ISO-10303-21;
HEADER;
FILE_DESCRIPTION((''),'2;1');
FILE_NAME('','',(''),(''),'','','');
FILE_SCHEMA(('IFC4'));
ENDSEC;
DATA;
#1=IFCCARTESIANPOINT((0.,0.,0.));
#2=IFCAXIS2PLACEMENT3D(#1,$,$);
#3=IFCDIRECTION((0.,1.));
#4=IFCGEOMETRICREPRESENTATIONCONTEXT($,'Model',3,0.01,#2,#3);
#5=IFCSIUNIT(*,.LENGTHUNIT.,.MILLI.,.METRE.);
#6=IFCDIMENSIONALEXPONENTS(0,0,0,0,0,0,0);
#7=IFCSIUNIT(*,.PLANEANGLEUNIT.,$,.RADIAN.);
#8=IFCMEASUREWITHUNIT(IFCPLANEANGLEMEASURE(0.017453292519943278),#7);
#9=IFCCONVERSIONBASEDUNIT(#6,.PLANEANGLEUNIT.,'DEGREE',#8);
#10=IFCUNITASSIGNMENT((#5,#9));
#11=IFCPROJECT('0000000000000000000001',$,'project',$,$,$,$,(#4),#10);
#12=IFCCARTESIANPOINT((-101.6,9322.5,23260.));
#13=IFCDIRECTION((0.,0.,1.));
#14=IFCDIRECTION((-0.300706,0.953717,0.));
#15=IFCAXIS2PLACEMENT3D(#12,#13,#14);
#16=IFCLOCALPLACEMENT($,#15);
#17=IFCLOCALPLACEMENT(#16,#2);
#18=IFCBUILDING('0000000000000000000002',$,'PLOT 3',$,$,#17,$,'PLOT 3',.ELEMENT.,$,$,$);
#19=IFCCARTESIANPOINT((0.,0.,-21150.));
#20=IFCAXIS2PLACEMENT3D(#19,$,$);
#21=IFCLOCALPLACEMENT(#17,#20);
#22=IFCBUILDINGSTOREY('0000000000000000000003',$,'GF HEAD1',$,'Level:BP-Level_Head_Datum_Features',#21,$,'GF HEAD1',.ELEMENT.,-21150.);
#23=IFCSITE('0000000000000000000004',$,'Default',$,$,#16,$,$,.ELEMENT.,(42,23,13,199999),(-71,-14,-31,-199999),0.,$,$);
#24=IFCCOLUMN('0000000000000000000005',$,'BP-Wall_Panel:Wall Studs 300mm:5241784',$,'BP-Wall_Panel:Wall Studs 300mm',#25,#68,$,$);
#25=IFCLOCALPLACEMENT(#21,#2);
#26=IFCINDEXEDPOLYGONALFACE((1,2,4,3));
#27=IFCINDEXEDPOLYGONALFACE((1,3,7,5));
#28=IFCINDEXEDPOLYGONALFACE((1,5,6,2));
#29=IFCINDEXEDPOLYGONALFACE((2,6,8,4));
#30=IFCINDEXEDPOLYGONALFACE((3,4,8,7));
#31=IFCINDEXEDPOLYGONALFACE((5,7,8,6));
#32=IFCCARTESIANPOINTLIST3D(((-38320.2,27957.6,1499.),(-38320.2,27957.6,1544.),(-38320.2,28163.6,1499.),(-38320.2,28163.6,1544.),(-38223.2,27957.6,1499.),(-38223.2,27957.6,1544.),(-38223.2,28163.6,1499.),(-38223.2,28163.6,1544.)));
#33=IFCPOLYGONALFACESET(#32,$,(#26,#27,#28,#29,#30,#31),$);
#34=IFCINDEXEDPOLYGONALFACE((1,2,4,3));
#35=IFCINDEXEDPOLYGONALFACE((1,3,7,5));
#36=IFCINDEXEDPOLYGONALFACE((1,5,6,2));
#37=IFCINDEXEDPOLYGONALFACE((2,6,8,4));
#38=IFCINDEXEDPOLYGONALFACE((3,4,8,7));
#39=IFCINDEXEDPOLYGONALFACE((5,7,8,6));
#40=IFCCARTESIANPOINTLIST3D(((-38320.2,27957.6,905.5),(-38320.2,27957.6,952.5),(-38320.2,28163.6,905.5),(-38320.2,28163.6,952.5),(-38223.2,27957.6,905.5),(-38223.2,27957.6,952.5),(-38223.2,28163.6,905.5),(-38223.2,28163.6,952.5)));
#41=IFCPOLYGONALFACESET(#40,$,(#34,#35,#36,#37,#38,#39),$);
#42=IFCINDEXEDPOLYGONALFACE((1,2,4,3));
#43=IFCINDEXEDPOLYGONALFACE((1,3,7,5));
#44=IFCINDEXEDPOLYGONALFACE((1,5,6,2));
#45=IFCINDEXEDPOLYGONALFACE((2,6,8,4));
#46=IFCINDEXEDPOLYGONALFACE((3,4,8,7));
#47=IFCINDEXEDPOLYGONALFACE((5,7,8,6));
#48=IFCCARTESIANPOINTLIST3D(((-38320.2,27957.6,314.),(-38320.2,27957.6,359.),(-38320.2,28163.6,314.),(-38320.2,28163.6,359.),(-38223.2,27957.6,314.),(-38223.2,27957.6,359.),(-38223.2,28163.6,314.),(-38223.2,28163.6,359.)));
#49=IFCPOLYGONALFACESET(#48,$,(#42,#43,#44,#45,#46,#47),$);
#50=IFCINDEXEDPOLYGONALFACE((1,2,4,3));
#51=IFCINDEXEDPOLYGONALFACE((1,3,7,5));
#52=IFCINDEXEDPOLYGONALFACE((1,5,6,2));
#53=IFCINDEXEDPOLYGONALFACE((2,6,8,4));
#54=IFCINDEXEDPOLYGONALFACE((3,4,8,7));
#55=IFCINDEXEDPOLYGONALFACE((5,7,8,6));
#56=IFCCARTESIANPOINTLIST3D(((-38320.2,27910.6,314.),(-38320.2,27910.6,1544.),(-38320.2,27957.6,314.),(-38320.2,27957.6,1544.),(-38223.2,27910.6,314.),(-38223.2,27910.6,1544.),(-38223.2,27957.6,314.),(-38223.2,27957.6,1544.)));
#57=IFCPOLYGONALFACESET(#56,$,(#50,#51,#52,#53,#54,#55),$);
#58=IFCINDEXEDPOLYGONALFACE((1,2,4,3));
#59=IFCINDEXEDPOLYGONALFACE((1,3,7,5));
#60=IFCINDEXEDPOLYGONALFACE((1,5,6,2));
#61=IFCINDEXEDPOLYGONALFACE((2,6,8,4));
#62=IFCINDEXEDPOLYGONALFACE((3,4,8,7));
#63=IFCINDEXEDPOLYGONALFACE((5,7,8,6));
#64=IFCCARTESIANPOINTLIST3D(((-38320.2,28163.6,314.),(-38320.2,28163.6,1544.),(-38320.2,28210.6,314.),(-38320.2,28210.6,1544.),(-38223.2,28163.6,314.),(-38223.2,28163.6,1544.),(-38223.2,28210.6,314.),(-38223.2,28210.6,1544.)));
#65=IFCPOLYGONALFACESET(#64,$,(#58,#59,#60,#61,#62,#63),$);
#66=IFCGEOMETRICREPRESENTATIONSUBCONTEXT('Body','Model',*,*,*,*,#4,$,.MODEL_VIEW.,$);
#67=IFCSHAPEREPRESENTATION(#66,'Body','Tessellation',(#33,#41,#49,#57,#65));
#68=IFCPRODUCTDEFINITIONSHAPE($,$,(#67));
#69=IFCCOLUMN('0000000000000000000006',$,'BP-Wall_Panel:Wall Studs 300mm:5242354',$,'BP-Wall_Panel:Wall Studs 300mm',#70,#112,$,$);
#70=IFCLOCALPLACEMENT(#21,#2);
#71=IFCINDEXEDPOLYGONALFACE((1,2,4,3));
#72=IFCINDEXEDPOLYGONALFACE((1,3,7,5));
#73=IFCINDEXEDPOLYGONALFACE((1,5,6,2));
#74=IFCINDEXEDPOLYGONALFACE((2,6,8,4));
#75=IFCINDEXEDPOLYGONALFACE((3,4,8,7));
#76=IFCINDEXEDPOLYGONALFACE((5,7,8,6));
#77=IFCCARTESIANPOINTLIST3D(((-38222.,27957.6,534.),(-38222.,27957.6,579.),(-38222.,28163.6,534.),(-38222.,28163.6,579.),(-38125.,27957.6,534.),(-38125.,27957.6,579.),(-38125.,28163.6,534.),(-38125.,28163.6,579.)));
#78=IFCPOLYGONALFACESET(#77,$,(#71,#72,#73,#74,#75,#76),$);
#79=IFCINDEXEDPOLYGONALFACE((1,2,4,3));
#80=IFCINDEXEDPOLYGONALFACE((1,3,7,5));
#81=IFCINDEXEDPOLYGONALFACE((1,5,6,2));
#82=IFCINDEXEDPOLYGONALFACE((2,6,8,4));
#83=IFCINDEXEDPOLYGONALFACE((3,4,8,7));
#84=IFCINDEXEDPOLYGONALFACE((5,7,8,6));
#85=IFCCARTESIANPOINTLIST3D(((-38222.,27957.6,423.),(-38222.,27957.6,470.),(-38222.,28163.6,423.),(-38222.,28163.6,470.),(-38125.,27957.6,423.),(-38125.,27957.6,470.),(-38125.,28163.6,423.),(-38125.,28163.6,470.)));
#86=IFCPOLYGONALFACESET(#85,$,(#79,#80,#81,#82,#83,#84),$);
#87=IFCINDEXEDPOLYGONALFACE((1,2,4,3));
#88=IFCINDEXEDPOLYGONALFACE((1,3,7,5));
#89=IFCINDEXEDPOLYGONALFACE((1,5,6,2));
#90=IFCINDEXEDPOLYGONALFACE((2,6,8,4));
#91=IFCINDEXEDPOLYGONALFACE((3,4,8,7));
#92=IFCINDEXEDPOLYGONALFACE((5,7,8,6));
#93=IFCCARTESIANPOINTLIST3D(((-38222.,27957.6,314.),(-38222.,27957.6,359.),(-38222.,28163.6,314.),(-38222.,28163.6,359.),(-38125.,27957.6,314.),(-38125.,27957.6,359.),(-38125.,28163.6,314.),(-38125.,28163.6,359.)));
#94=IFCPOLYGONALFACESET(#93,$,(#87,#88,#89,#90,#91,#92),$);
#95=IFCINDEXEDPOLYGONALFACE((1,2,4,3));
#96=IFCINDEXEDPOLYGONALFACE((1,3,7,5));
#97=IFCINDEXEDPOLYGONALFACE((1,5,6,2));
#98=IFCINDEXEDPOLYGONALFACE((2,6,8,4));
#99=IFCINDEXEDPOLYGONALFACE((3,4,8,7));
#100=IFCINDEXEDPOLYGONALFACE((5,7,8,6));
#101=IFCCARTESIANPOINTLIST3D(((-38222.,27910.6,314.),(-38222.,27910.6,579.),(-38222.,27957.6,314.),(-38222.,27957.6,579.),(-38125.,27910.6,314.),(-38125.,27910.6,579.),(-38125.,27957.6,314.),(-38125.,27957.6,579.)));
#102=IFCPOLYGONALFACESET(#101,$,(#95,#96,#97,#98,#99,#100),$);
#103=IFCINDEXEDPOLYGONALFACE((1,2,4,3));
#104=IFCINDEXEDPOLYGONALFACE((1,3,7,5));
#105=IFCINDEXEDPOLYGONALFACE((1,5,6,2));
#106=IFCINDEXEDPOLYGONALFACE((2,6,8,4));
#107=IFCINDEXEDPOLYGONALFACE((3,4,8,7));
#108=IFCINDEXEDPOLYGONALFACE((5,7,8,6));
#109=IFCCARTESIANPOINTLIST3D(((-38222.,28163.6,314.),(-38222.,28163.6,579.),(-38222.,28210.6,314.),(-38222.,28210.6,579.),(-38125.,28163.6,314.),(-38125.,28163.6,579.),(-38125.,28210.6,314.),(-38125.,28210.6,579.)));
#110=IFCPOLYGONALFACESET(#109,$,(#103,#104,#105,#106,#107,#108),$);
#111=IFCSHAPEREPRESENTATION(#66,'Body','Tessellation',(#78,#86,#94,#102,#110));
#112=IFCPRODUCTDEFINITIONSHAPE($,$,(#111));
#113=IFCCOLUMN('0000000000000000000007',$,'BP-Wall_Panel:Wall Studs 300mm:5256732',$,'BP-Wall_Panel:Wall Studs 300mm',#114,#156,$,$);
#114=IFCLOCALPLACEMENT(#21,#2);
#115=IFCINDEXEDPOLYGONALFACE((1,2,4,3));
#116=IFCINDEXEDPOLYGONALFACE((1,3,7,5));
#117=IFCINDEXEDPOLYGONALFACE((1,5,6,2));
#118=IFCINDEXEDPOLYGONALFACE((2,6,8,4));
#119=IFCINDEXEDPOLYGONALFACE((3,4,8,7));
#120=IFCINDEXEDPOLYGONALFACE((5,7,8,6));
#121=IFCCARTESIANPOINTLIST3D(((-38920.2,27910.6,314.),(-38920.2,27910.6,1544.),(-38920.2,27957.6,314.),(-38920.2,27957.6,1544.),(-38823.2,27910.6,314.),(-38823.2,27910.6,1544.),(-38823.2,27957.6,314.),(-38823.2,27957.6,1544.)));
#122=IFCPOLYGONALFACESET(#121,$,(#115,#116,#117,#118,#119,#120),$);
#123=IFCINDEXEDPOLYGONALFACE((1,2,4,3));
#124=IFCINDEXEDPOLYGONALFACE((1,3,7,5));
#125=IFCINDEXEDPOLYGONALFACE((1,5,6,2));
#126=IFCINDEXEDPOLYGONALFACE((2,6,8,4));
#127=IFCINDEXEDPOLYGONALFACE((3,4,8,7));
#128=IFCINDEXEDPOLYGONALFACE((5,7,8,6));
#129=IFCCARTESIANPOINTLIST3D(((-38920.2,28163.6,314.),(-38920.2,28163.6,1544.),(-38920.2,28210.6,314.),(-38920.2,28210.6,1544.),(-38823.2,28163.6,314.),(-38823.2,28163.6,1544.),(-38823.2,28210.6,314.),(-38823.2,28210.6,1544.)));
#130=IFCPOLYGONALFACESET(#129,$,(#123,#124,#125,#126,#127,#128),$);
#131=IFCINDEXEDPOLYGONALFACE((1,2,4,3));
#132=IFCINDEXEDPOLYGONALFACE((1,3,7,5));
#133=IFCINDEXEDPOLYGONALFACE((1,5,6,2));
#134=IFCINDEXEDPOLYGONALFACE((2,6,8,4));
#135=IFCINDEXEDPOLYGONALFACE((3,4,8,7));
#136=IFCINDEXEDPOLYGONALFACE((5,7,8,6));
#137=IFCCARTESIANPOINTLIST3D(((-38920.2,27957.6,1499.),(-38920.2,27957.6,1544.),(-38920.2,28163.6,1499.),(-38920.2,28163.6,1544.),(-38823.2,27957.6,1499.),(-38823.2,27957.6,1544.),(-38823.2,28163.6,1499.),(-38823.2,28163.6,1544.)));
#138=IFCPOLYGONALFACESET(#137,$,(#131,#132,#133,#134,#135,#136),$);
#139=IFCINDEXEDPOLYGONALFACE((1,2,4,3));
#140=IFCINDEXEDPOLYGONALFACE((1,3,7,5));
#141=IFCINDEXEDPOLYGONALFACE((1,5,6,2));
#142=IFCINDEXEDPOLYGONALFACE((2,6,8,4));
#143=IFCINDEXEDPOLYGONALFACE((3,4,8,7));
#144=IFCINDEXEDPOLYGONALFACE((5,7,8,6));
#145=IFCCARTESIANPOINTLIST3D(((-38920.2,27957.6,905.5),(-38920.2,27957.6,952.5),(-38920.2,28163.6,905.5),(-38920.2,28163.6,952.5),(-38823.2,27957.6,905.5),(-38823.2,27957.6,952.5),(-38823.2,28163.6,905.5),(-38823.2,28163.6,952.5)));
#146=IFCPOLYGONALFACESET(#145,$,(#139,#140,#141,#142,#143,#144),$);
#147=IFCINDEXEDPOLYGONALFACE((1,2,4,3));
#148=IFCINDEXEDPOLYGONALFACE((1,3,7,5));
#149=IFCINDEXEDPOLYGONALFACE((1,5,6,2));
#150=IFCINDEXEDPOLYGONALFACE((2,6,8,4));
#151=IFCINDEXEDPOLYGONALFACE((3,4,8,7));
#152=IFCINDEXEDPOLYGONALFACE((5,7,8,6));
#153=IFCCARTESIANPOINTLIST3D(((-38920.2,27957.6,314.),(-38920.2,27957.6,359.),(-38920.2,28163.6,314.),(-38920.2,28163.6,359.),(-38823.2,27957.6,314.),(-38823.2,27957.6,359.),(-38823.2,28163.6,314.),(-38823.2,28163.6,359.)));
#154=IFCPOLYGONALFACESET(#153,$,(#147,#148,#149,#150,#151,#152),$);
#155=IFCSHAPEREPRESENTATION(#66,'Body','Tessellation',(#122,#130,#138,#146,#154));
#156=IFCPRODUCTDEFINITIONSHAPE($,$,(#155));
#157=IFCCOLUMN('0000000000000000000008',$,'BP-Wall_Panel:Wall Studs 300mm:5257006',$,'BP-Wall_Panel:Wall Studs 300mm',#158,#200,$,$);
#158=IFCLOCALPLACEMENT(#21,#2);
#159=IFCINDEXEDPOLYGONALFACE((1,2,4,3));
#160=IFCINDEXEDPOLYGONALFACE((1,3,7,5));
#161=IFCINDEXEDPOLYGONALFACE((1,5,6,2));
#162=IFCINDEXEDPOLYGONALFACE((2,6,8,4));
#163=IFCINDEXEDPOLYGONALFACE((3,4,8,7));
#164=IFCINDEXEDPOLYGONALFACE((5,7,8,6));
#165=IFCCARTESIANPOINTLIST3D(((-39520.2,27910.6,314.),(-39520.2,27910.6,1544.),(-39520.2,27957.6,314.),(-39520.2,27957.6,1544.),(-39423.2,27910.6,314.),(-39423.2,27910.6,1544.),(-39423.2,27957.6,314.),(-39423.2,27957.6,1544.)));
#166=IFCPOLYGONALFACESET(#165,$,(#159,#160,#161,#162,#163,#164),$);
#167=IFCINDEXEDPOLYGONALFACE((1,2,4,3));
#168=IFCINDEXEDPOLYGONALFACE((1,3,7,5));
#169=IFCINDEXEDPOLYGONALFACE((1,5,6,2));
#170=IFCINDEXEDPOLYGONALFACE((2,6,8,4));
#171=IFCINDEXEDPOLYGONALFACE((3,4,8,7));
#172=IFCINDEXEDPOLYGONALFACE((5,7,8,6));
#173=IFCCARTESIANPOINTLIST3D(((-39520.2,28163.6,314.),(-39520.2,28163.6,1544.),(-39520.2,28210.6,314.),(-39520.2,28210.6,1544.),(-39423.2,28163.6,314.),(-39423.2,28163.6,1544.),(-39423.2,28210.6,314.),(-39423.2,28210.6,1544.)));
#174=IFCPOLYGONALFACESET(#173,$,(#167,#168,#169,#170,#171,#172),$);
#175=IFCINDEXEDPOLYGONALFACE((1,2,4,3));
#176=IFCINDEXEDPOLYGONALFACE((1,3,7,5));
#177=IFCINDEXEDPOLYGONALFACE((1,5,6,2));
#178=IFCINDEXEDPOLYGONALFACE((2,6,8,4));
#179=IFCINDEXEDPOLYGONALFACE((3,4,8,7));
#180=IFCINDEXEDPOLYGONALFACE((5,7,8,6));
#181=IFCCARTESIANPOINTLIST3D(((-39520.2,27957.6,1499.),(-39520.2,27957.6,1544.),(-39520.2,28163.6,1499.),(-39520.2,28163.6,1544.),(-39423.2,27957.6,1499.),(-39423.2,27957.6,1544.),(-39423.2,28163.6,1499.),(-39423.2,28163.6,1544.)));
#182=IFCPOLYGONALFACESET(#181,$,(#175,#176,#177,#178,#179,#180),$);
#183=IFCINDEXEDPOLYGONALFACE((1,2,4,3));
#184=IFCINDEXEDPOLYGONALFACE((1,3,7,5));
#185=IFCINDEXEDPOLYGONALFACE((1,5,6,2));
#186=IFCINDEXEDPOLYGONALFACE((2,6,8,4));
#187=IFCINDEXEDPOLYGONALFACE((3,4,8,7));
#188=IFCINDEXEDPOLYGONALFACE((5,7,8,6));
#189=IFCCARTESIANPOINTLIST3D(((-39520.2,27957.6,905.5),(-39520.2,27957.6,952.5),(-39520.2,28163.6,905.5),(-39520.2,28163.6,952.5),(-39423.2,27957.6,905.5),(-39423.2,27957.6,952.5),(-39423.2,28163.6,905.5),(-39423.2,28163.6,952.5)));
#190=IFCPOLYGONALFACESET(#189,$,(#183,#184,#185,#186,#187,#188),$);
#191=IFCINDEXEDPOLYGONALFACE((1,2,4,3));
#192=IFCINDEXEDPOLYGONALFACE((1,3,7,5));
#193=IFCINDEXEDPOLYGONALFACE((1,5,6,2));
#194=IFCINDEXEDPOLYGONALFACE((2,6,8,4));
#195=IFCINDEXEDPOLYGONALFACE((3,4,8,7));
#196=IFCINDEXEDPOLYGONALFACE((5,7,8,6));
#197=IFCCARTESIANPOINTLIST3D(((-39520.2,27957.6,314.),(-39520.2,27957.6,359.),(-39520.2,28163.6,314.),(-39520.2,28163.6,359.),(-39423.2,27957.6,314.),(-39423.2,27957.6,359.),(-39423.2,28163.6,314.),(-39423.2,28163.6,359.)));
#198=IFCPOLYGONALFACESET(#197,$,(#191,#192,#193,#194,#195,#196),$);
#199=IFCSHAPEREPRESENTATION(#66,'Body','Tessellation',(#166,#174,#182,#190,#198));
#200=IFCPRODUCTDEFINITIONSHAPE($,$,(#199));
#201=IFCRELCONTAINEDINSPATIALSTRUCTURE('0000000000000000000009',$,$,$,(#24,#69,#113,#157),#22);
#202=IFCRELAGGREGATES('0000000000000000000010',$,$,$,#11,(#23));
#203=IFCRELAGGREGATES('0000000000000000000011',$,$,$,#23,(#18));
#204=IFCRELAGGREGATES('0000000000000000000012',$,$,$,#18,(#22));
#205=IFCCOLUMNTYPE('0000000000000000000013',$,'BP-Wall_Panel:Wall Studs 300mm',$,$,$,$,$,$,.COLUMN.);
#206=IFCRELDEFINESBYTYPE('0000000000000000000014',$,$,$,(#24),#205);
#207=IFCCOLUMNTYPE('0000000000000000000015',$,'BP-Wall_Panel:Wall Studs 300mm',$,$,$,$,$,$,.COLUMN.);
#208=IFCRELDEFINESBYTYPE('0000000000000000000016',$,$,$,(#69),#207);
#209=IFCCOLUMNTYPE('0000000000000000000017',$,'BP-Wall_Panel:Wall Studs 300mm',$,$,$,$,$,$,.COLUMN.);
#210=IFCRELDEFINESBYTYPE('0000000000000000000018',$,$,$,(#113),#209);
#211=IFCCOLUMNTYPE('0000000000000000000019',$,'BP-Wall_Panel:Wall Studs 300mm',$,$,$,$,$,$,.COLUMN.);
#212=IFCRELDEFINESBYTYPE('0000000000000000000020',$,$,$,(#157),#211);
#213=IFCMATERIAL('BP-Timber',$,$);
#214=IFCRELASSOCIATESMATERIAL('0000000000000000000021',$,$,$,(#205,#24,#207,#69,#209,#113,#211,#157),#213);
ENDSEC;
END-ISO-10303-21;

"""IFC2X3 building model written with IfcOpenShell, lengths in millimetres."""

from ifc_helpers import new_model, entity, si_unit, converted_unit, direction, frame, frame_2d, origin, place, context, subcontext, project, spatial, rectangle, extrude, source, transform, mapped, material, type_object, type_shapes, element, save


model = new_model("IFC2X3")

# Units and contexts
model_context = context("Model", 3, precision=0.01, world=origin(), true_north=direction((0.0, 1.0)))
body_context = subcontext(model_context, "Body", "Model", "MODEL_VIEW")
ifc_project = project(units=[si_unit("LENGTHUNIT", "METRE", prefix="MILLI"), converted_unit("PLANEANGLEUNIT", "DEGREE", entity("IfcPlaneAngleMeasure", 0.017453292519943278), si_unit("PLANEANGLEUNIT", "RADIAN"), dimensions=[0, 0, 0, 0, 0, 0, 0])], contexts=[model_context])

# Site, building, storey
site_placement = place(None, frame((-101.6, 9322.5, 23260.0), z_axis=(0.0, 0.0, 1.0), x_axis=(-0.300706, 0.953717, 0.0)))
site = spatial("IfcSite", under=ifc_project, at=site_placement, Name="Default", CompositionType="ELEMENT", RefLatitude=(42, 23, 13, 199999), RefLongitude=(-71, -14, -31, -199999), RefElevation=0.0)
building_placement = place(site_placement, origin())
building = spatial("IfcBuilding", under=site, at=building_placement, Name="PLOT 3", LongName="PLOT 3", CompositionType="ELEMENT")
storey_placement = place(building_placement, frame((0.0, 0.0, -21150.0)))
storey = spatial("IfcBuildingStorey", under=building, at=storey_placement, Name="GF HEAD1", ObjectType="Level:BP-Level_Head_Datum_Features", LongName="GF HEAD1", CompositionType="ELEMENT", Elevation=-21150.0)

# Columns
ifc_material_1 = material(Name="BP-Timber")
column_type_1 = type_object("IfcColumnType", Name="BP-Wall_Panel:Wall Studs 300mm", PredefinedType="COLUMN", material=ifc_material_1)
shared_shape_1 = source(origin(), body_context, "Body", "SweptSolid", [
    extrude(rectangle(XDim=97.0, YDim=206.0, at=frame_2d((0.0, 0.0), x_axis=(1.0, 0.0))), frame((-38271.7, 28060.6, -19651.0)), (0.0, 0.0, 1.0), 45.0),
    extrude(rectangle(XDim=97.0, YDim=206.0, at=frame_2d((0.0, 0.0), x_axis=(1.0, 0.0))), frame((-38271.7, 28060.6, -20244.5)), (0.0, 0.0, 1.0), 47.0),
    extrude(rectangle(XDim=97.0, YDim=206.0, at=frame_2d((0.0, 0.0), x_axis=(1.0, 0.0))), frame((-38271.7, 28060.6, -20836.0)), (0.0, 0.0, 1.0), 45.0),
    extrude(rectangle(XDim=47.0, YDim=97.0, at=frame_2d((0.0, 0.0), x_axis=(1.0, 0.0))), frame((-38271.7, 27934.1, -20836.0), z_axis=(0.0, 0.0, 1.0), x_axis=(0.0, 1.0, 0.0)), (0.0, 0.0, 1.0), 1230.0),
    extrude(rectangle(XDim=47.0, YDim=97.0, at=frame_2d((0.0, 0.0), x_axis=(1.0, 0.0))), frame((-38271.7, 28187.1, -20836.0), z_axis=(0.0, 0.0, 1.0), x_axis=(0.0, 1.0, 0.0)), (0.0, 0.0, 1.0), 1230.0),
])
type_shapes(column_type_1, [shared_shape_1])
column_1_placement = place(storey_placement, frame((0.0, 0.0, 21150.0)))
element("IfcColumn", 1, at=column_1_placement, inside=storey, type_object=column_type_1, material=ifc_material_1, Name="BP-Wall_Panel:Wall Studs 300mm:5241784", ObjectType="BP-Wall_Panel:Wall Studs 300mm", context=body_context, shape_type="MappedRepresentation", body=[
    mapped(shared_shape_1, transform((0.0, 0.0, 0.0), scale=1.0)),
])
column_type_2 = type_object("IfcColumnType", Name="BP-Wall_Panel:Wall Studs 300mm", PredefinedType="COLUMN", material=ifc_material_1)
shared_shape_2 = source(origin(), body_context, "Body", "SweptSolid", [
    extrude(rectangle(XDim=97.0, YDim=206.0, at=frame_2d((0.0, 0.0), x_axis=(1.0, 0.0))), frame((-38173.5, 28060.6, -20616.0)), (0.0, 0.0, 1.0), 45.0),
    extrude(rectangle(XDim=97.0, YDim=206.0, at=frame_2d((0.0, 0.0), x_axis=(1.0, 0.0))), frame((-38173.5, 28060.6, -20727.0)), (0.0, 0.0, 1.0), 47.0),
    extrude(rectangle(XDim=97.0, YDim=206.0, at=frame_2d((0.0, 0.0), x_axis=(1.0, 0.0))), frame((-38173.5, 28060.6, -20836.0)), (0.0, 0.0, 1.0), 45.0),
    extrude(rectangle(XDim=47.0, YDim=97.0, at=frame_2d((0.0, 0.0), x_axis=(1.0, 0.0))), frame((-38173.5, 27934.1, -20836.0), z_axis=(0.0, 0.0, 1.0), x_axis=(0.0, 1.0, 0.0)), (0.0, 0.0, 1.0), 265.0),
    extrude(rectangle(XDim=47.0, YDim=97.0, at=frame_2d((0.0, 0.0), x_axis=(1.0, 0.0))), frame((-38173.5, 28187.1, -20836.0), z_axis=(0.0, 0.0, 1.0), x_axis=(0.0, 1.0, 0.0)), (0.0, 0.0, 1.0), 265.0),
])
type_shapes(column_type_2, [shared_shape_2])
column_2_placement = place(storey_placement, frame((0.0, 0.0, 21150.0)))
element("IfcColumn", 2, at=column_2_placement, inside=storey, type_object=column_type_2, material=ifc_material_1, Name="BP-Wall_Panel:Wall Studs 300mm:5242354", ObjectType="BP-Wall_Panel:Wall Studs 300mm", context=body_context, shape_type="MappedRepresentation", body=[
    mapped(shared_shape_2, transform((0.0, 0.0, 0.0), scale=1.0)),
])
column_type_3 = type_object("IfcColumnType", Name="BP-Wall_Panel:Wall Studs 300mm", PredefinedType="COLUMN", material=ifc_material_1)
shared_shape_3 = source(origin(), body_context, "Body", "SweptSolid", [
    extrude(rectangle(XDim=47.0, YDim=97.0, at=frame_2d((0.0, 0.0), x_axis=(1.0, 0.0))), frame((-38871.7, 27934.1, -20836.0), z_axis=(0.0, 0.0, 1.0), x_axis=(0.0, 1.0, 0.0)), (0.0, 0.0, 1.0), 1230.0),
    extrude(rectangle(XDim=47.0, YDim=97.0, at=frame_2d((0.0, 0.0), x_axis=(1.0, 0.0))), frame((-38871.7, 28187.1, -20836.0), z_axis=(0.0, 0.0, 1.0), x_axis=(0.0, 1.0, 0.0)), (0.0, 0.0, 1.0), 1230.0),
    extrude(rectangle(XDim=97.0, YDim=206.0, at=frame_2d((0.0, 0.0), x_axis=(1.0, 0.0))), frame((-38871.7, 28060.6, -19651.0)), (0.0, 0.0, 1.0), 45.0),
    extrude(rectangle(XDim=97.0, YDim=206.0, at=frame_2d((0.0, 0.0), x_axis=(1.0, 0.0))), frame((-38871.7, 28060.6, -20244.5)), (0.0, 0.0, 1.0), 47.0),
    extrude(rectangle(XDim=97.0, YDim=206.0, at=frame_2d((0.0, 0.0), x_axis=(1.0, 0.0))), frame((-38871.7, 28060.6, -20836.0)), (0.0, 0.0, 1.0), 45.0),
])
type_shapes(column_type_3, [shared_shape_3])
column_3_placement = place(storey_placement, frame((0.0, 0.0, 21150.0)))
element("IfcColumn", 3, at=column_3_placement, inside=storey, type_object=column_type_3, material=ifc_material_1, Name="BP-Wall_Panel:Wall Studs 300mm:5256732", ObjectType="BP-Wall_Panel:Wall Studs 300mm", context=body_context, shape_type="MappedRepresentation", body=[
    mapped(shared_shape_3, transform((0.0, 0.0, 0.0), scale=1.0)),
])
column_type_4 = type_object("IfcColumnType", Name="BP-Wall_Panel:Wall Studs 300mm", PredefinedType="COLUMN", material=ifc_material_1)
shared_shape_4 = source(origin(), body_context, "Body", "SweptSolid", [
    extrude(rectangle(XDim=47.0, YDim=97.0, at=frame_2d((0.0, 0.0), x_axis=(1.0, 0.0))), frame((-39471.7, 27934.1, -20836.0), z_axis=(0.0, 0.0, 1.0), x_axis=(0.0, 1.0, 0.0)), (0.0, 0.0, 1.0), 1230.0),
    extrude(rectangle(XDim=47.0, YDim=97.0, at=frame_2d((0.0, 0.0), x_axis=(1.0, 0.0))), frame((-39471.7, 28187.1, -20836.0), z_axis=(0.0, 0.0, 1.0), x_axis=(0.0, 1.0, 0.0)), (0.0, 0.0, 1.0), 1230.0),
    extrude(rectangle(XDim=97.0, YDim=206.0, at=frame_2d((0.0, 0.0), x_axis=(1.0, 0.0))), frame((-39471.7, 28060.6, -19651.0)), (0.0, 0.0, 1.0), 45.0),
    extrude(rectangle(XDim=97.0, YDim=206.0, at=frame_2d((0.0, 0.0), x_axis=(1.0, 0.0))), frame((-39471.7, 28060.6, -20244.5)), (0.0, 0.0, 1.0), 47.0),
    extrude(rectangle(XDim=97.0, YDim=206.0, at=frame_2d((0.0, 0.0), x_axis=(1.0, 0.0))), frame((-39471.7, 28060.6, -20836.0)), (0.0, 0.0, 1.0), 45.0),
])
type_shapes(column_type_4, [shared_shape_4])
column_4_placement = place(storey_placement, frame((0.0, 0.0, 21150.0)))
element("IfcColumn", 4, at=column_4_placement, inside=storey, type_object=column_type_4, material=ifc_material_1, Name="BP-Wall_Panel:Wall Studs 300mm:5257006", ObjectType="BP-Wall_Panel:Wall Studs 300mm", context=body_context, shape_type="MappedRepresentation", body=[
    mapped(shared_shape_4, transform((0.0, 0.0, 0.0), scale=1.0)),
])

save(model, "model.ifc")
